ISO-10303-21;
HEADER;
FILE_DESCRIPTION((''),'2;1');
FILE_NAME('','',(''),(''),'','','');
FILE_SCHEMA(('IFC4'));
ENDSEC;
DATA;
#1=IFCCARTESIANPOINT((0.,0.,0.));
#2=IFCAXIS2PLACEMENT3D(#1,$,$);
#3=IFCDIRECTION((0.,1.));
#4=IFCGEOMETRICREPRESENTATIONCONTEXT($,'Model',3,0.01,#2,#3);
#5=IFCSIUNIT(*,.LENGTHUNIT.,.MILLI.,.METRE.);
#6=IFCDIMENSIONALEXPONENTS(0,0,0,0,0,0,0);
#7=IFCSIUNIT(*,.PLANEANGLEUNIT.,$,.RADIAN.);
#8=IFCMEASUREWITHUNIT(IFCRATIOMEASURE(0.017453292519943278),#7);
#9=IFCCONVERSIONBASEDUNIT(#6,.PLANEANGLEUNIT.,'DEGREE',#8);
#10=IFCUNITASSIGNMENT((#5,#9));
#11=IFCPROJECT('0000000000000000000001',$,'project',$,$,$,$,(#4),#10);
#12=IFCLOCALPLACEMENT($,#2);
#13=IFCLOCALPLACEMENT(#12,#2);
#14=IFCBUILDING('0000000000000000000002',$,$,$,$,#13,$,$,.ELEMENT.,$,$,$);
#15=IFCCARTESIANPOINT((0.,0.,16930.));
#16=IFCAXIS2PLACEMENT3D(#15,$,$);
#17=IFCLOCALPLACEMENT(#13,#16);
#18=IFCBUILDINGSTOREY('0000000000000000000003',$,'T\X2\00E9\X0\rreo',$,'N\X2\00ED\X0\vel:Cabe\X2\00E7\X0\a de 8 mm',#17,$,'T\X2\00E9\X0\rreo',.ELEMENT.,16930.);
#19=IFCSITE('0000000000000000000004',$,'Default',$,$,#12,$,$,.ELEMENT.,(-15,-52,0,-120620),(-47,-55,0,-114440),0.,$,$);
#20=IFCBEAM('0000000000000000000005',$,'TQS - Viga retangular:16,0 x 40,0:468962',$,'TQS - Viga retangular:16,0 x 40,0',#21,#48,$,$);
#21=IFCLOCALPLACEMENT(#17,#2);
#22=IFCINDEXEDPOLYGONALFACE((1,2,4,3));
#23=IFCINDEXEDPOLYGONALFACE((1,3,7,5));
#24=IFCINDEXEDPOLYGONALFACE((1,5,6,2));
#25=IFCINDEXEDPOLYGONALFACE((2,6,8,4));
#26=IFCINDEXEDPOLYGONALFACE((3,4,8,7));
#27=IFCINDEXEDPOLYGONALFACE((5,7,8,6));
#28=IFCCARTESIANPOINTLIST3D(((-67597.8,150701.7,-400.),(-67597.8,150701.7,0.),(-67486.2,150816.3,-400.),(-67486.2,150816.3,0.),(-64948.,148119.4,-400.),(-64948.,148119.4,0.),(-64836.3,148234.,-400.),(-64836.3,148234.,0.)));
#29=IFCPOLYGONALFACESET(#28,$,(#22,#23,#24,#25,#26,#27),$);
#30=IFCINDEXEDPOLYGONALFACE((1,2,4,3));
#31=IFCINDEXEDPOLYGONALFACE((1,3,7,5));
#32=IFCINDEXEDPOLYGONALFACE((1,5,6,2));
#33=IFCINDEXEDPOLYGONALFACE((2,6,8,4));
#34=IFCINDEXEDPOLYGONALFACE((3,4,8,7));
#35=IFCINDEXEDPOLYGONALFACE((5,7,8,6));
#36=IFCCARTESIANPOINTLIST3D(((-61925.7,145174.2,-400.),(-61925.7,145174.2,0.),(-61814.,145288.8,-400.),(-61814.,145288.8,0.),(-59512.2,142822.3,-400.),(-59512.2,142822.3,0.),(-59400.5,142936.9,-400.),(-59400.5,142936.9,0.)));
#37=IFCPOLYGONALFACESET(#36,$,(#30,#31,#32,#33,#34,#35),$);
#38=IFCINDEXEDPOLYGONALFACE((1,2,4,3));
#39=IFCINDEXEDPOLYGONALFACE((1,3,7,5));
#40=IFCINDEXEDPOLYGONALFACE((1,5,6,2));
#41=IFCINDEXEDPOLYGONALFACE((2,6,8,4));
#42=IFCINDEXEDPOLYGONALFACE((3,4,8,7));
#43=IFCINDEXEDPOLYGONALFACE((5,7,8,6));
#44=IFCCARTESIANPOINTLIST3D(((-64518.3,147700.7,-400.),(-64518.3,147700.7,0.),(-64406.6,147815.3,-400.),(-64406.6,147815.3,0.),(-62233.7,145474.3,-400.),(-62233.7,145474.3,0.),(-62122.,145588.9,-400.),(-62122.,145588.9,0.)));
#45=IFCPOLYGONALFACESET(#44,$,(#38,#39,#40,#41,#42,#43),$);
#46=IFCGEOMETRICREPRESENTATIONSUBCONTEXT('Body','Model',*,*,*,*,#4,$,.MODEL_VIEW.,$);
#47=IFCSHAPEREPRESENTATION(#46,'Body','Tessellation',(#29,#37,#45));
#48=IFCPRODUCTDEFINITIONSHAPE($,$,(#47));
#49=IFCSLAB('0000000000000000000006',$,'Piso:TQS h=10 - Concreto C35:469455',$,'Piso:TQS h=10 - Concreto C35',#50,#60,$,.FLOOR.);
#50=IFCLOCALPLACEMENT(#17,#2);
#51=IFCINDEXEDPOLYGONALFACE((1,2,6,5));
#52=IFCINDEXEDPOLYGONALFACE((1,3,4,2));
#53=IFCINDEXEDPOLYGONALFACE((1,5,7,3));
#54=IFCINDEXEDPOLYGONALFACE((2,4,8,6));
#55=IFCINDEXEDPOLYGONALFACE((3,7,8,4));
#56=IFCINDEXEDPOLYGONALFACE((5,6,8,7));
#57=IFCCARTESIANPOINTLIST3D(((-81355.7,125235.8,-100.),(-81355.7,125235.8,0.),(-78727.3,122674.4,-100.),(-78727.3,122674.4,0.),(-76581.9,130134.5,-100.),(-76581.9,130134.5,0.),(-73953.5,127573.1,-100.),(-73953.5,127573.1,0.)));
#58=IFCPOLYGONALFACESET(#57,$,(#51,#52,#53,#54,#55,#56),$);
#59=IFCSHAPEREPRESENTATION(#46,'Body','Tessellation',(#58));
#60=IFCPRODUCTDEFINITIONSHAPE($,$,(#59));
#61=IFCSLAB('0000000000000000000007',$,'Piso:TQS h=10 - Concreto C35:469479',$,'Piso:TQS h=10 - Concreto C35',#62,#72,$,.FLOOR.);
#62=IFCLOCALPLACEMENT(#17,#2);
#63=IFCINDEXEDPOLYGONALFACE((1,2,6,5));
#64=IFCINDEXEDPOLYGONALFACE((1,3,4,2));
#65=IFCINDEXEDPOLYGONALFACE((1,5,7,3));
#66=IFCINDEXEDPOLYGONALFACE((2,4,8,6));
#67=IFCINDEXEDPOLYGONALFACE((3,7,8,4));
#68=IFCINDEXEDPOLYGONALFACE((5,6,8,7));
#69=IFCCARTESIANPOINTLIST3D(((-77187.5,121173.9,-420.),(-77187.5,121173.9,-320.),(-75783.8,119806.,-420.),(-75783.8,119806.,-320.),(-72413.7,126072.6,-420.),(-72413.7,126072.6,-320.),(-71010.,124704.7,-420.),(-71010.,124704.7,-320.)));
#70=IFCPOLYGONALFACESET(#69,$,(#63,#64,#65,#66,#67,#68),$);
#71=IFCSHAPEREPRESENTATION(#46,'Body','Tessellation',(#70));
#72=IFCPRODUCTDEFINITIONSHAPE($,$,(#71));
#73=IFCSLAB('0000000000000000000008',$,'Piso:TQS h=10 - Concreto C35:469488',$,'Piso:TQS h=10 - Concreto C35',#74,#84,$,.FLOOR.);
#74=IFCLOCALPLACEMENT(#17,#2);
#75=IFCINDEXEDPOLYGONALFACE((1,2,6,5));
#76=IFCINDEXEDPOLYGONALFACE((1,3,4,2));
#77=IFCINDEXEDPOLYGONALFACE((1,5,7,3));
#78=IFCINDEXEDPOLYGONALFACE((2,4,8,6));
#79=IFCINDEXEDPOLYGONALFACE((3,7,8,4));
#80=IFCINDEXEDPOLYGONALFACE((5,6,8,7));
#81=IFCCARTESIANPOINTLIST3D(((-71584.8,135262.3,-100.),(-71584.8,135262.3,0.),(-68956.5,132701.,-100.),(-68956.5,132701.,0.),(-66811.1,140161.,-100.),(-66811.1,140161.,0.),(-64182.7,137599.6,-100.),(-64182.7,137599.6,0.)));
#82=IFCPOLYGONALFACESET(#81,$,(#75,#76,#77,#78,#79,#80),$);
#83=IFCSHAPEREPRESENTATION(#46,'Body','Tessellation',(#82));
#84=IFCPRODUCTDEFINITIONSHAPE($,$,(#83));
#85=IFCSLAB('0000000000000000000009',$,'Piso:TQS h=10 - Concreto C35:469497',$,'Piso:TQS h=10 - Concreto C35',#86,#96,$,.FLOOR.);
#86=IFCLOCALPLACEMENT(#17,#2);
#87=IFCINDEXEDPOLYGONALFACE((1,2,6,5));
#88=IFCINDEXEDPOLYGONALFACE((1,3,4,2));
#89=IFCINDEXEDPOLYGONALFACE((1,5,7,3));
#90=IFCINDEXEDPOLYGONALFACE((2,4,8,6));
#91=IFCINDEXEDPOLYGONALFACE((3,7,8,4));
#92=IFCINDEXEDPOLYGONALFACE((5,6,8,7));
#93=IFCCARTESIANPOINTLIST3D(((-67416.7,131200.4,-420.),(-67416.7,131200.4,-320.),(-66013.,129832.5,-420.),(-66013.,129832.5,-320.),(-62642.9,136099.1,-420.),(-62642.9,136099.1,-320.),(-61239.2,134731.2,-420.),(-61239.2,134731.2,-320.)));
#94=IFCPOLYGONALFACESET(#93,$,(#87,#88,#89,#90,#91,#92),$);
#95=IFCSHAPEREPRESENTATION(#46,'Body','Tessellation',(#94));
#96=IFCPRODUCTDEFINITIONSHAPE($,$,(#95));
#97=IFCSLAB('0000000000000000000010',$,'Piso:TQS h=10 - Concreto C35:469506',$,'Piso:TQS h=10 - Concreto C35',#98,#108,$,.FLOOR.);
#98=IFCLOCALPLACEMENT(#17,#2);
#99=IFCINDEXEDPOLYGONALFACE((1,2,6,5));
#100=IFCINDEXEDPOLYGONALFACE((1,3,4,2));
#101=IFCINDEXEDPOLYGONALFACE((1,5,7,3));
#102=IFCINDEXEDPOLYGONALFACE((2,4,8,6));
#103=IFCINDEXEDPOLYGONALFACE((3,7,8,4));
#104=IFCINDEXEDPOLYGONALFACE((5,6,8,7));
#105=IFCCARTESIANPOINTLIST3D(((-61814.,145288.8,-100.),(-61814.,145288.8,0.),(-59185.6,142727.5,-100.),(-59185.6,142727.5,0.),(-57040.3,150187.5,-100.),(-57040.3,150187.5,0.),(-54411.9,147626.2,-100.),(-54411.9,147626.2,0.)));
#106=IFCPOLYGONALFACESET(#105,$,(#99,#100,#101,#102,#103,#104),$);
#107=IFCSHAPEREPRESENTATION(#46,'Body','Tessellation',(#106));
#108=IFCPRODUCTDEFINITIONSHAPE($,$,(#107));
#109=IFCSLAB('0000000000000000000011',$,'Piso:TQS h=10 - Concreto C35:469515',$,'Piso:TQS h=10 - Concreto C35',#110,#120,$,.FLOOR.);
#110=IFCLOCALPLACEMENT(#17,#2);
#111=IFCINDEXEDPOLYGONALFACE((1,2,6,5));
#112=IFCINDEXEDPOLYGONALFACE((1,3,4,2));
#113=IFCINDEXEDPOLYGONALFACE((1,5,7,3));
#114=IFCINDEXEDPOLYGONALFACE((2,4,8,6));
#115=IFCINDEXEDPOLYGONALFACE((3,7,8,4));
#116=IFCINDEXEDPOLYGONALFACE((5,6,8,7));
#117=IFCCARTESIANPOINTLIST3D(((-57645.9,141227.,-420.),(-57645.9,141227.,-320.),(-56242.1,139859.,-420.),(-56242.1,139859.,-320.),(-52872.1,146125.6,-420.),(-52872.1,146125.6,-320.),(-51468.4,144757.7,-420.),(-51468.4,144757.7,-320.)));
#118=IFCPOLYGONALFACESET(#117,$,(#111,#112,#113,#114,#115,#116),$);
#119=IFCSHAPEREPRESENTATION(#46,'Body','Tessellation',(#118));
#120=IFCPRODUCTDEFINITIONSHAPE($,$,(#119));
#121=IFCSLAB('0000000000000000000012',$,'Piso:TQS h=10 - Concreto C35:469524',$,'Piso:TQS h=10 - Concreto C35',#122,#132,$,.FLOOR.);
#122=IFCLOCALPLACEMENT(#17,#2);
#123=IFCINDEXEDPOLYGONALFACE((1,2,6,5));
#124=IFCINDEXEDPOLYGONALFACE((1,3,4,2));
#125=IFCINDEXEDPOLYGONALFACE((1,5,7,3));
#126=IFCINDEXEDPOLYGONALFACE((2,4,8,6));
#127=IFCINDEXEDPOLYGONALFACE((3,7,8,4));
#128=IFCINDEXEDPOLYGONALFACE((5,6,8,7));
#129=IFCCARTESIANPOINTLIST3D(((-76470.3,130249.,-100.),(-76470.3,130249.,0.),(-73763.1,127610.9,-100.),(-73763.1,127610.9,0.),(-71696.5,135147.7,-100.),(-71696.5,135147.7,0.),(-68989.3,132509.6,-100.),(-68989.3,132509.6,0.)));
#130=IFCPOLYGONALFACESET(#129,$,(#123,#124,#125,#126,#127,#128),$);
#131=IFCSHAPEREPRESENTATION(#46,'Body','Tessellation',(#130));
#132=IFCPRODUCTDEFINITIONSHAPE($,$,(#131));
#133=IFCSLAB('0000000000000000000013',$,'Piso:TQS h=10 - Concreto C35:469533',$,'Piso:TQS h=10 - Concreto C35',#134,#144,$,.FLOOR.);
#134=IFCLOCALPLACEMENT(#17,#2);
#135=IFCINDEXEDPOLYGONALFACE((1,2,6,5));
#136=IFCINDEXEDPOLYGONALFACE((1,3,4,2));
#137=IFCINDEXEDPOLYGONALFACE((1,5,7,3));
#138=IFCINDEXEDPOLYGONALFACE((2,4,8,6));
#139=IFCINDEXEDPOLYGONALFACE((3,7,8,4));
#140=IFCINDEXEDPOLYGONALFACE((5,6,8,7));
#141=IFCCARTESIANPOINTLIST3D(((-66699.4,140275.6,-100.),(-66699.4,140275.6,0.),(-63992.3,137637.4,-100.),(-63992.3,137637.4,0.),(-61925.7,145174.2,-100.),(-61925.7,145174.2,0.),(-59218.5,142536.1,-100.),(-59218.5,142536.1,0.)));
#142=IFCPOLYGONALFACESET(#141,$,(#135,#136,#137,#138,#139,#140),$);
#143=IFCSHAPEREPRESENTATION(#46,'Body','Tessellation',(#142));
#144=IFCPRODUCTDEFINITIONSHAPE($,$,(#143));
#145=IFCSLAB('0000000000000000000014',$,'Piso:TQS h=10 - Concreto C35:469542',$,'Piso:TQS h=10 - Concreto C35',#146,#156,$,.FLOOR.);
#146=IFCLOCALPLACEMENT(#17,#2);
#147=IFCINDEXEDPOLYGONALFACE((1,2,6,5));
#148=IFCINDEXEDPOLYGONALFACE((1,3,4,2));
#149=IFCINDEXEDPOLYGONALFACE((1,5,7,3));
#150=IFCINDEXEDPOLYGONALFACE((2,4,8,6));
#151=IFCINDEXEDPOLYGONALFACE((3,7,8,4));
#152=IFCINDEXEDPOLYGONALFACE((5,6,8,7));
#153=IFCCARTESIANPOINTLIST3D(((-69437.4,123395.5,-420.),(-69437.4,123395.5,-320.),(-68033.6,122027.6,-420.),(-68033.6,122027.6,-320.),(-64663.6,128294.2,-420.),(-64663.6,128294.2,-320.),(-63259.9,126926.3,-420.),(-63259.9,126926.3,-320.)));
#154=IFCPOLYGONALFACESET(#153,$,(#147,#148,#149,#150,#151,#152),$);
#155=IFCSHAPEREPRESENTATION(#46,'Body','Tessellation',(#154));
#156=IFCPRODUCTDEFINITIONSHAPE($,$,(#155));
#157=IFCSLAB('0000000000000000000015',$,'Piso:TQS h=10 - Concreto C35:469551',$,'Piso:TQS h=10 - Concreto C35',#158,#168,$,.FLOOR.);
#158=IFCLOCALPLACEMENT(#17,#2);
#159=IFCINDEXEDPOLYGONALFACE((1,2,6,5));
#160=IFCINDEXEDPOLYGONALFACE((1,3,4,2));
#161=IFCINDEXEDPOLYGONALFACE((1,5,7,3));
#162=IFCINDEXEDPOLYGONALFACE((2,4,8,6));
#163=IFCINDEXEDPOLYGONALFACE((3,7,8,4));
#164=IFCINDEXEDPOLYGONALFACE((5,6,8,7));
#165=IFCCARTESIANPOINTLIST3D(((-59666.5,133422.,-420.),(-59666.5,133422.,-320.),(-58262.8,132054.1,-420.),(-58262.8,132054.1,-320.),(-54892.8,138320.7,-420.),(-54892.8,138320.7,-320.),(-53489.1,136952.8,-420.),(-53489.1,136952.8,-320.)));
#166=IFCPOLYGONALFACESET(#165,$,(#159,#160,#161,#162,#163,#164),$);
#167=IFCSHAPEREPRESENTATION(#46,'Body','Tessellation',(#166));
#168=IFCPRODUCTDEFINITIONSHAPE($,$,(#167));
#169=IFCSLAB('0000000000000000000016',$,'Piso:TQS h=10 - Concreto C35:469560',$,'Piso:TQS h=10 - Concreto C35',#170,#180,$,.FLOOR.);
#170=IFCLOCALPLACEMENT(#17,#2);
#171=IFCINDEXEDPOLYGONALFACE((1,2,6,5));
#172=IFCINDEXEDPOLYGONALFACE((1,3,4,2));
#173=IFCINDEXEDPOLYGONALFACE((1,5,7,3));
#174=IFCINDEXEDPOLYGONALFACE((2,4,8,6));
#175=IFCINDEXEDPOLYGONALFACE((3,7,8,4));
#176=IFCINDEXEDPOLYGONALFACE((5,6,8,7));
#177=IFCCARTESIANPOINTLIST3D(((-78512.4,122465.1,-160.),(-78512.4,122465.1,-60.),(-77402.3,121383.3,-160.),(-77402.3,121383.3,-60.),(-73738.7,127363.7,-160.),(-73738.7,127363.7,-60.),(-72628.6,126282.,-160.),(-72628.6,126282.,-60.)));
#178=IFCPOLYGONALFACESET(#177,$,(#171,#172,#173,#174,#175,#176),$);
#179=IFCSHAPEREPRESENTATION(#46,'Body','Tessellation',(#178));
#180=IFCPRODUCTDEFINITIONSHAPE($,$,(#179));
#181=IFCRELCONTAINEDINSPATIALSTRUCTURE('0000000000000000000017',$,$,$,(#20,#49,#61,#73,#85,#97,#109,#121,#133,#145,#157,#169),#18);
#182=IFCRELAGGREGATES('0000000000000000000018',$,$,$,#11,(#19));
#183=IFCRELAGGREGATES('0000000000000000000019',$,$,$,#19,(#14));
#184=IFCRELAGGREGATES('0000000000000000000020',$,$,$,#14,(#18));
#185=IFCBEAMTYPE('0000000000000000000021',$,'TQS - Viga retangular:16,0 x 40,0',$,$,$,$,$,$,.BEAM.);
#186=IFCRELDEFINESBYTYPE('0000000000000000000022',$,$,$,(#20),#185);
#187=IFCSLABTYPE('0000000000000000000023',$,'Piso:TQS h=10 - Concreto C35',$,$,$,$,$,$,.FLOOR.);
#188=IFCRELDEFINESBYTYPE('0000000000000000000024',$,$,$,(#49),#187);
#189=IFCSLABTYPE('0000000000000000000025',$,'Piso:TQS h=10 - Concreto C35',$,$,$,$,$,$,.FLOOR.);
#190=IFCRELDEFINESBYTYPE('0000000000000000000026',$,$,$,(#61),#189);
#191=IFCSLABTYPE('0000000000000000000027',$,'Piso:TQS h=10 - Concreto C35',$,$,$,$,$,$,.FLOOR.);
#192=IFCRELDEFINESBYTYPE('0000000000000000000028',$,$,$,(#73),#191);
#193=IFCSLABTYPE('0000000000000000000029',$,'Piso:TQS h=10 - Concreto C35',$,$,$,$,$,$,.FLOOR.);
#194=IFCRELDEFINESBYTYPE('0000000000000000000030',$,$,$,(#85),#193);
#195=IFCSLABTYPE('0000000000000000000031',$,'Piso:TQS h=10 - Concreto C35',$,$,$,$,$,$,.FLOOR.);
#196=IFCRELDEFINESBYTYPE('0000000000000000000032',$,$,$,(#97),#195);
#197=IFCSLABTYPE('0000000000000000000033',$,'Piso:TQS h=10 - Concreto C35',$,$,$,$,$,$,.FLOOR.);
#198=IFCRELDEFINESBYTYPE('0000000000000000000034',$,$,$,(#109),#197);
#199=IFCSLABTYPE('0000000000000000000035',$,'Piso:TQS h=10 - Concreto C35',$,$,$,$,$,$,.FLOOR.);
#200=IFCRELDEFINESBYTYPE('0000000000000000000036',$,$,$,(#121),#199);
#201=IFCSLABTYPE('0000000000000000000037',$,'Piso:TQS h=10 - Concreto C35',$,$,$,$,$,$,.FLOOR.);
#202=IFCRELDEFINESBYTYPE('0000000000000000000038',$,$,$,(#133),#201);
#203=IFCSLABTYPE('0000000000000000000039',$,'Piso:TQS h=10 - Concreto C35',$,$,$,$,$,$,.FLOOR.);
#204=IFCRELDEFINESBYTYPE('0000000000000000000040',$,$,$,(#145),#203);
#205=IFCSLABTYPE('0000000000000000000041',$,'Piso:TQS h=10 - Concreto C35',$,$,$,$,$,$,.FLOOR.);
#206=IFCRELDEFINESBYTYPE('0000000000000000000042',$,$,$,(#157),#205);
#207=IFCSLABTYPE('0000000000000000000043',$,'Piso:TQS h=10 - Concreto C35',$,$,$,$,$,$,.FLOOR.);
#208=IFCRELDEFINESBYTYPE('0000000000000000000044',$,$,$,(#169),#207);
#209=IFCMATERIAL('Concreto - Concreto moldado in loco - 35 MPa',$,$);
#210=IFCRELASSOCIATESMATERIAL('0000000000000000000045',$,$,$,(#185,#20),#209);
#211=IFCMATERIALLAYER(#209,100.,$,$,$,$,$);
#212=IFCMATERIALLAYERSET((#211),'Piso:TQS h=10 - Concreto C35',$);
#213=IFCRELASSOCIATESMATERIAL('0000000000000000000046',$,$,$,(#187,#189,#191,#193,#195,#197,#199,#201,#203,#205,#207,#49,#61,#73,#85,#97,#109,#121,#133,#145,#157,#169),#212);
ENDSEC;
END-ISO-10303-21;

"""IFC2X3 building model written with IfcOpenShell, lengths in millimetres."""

from ifc_helpers import new_model, entity, si_unit, converted_unit, direction, frame, frame_2d, origin, place, context, subcontext, project, spatial, rectangle, extrude, source, transform, mapped, material, layer, layer_set, layer_usage, type_object, type_shapes, element, save


model = new_model("IFC2X3")

# Units and contexts
model_context = context("Model", 3, precision=0.01, world=origin(), true_north=direction((0.0, 1.0)))
body_context = subcontext(model_context, "Body", "Model", "MODEL_VIEW")
ifc_project = project(units=[si_unit("LENGTHUNIT", "METRE", prefix="MILLI"), converted_unit("PLANEANGLEUNIT", "DEGREE", entity("IfcRatioMeasure", 0.017453292519943278), si_unit("PLANEANGLEUNIT", "RADIAN"), dimensions=[0, 0, 0, 0, 0, 0, 0])], contexts=[model_context])

# Site, building, storey
site_placement = place(None, origin())
site = spatial("IfcSite", under=ifc_project, at=site_placement, Name="Default", CompositionType="ELEMENT", RefLatitude=(-15, -52, 0, -120620), RefLongitude=(-47, -55, 0, -114440), RefElevation=0.0)
building_placement = place(site_placement, origin())
building = spatial("IfcBuilding", under=site, at=building_placement, CompositionType="ELEMENT")
storey_placement = place(building_placement, frame((0.0, 0.0, 16930.0)))
storey = spatial("IfcBuildingStorey", under=building, at=storey_placement, Name="Térreo", ObjectType="Nível:Cabeça de 8 mm", LongName="Térreo", CompositionType="ELEMENT", Elevation=16930.0)

# Beam
ifc_material = material(Name="Concreto - Concreto moldado in loco - 35 MPa")
beam_type_1 = type_object("IfcBeamType", Name="TQS - Viga retangular:16,0 x 40,0", PredefinedType="BEAM", material=ifc_material)
shared_shape_1 = source(origin(), body_context, "Body", "SweptSolid", [
    extrude(rectangle(XDim=400.0, YDim=160.0, at=frame_2d((0.0, 0.0), x_axis=(1.0, 0.0))), frame((-64892.1, 148176.7, 16730.0), z_axis=(-0.71618, 0.697915, 0.0), x_axis=(0.0, 0.0, 1.0)), (0.0, 0.0, 1.0), 3700.0),
    extrude(rectangle(XDim=400.0, YDim=160.0, at=frame_2d((0.0, 0.0), x_axis=(1.0, 0.0))), frame((-59456.3, 142879.6, 16730.0), z_axis=(-0.71618, 0.697915, 0.0), x_axis=(0.0, 0.0, 1.0)), (0.0, 0.0, 1.0), 3370.0),
    extrude(rectangle(XDim=400.0, YDim=160.0, at=frame_2d((0.0, 0.0), x_axis=(1.0, 0.0))), frame((-62177.8, 145531.6, 16730.0), z_axis=(-0.71618, 0.697915, 0.0), x_axis=(0.0, 0.0, 1.0)), (0.0, 0.0, 1.0), 3190.0),
])
type_shapes(beam_type_1, [shared_shape_1])
beam_1_placement = place(storey_placement, frame((0.0, 0.0, -16930.0)))
element("IfcBeam", 1, at=beam_1_placement, inside=storey, type_object=beam_type_1, material=ifc_material, Name="TQS - Viga retangular:16,0 x 40,0:468962", ObjectType="TQS - Viga retangular:16,0 x 40,0", context=body_context, shape_type="MappedRepresentation", body=[
    mapped(shared_shape_1, transform((0.0, 0.0, 0.0), scale=1.0)),
])

# Slabs
ifc_layer = layer(ifc_material, 100.0)
ifc_layer_set = layer_set([ifc_layer], Name="Piso:TQS h=10 - Concreto C35")
ifc_layer_usage_1 = layer_usage(ifc_layer_set, "AXIS3", "POSITIVE", 0.0)
slab_type_1 = type_object("IfcSlabType", Name="Piso:TQS h=10 - Concreto C35", PredefinedType="FLOOR", material=ifc_layer_set)
slab_1_placement = place(storey_placement, origin())
element("IfcSlab", 2, at=slab_1_placement, inside=storey, type_object=slab_type_1, material=ifc_layer_usage_1, Name="Piso:TQS h=10 - Concreto C35:469455", ObjectType="Piso:TQS h=10 - Concreto C35", PredefinedType="FLOOR", context=body_context, shape_type="SweptSolid", body=[
    extrude(rectangle(XDim=3670.0, YDim=6840.0, at=frame_2d((0.0, 0.0), x_axis=(1.0, 0.0))), frame((-77654.6, 126404.4, 0.0), z_axis=(0.0, 0.0, -1.0), x_axis=(0.71618, -0.697915, 0.0)), (0.0, 0.0, 1.0), 100.0),
])
ifc_layer_usage_2 = layer_usage(ifc_layer_set, "AXIS3", "POSITIVE", 0.0)
slab_type_2 = type_object("IfcSlabType", Name="Piso:TQS h=10 - Concreto C35", PredefinedType="FLOOR", material=ifc_layer_set)
slab_2_placement = place(storey_placement, origin())
element("IfcSlab", 3, at=slab_2_placement, inside=storey, type_object=slab_type_2, material=ifc_layer_usage_2, Name="Piso:TQS h=10 - Concreto C35:469479", ObjectType="Piso:TQS h=10 - Concreto C35", PredefinedType="FLOOR", context=body_context, shape_type="SweptSolid", body=[
    extrude(rectangle(XDim=1960.0, YDim=6840.0, at=frame_2d((0.0, 0.0), x_axis=(1.0, 0.0))), frame((-74098.8, 122939.3, -320.0), z_axis=(0.0, 0.0, -1.0), x_axis=(0.71618, -0.697915, 0.0)), (0.0, 0.0, 1.0), 100.0),
])
ifc_layer_usage_3 = layer_usage(ifc_layer_set, "AXIS3", "POSITIVE", 0.0)
slab_type_3 = type_object("IfcSlabType", Name="Piso:TQS h=10 - Concreto C35", PredefinedType="FLOOR", material=ifc_layer_set)
slab_3_placement = place(storey_placement, origin())
element("IfcSlab", 4, at=slab_3_placement, inside=storey, type_object=slab_type_3, material=ifc_layer_usage_3, Name="Piso:TQS h=10 - Concreto C35:469488", ObjectType="Piso:TQS h=10 - Concreto C35", PredefinedType="FLOOR", context=body_context, shape_type="SweptSolid", body=[
    extrude(rectangle(XDim=3670.0, YDim=6840.0, at=frame_2d((0.0, 0.0), x_axis=(1.0, 0.0))), frame((-67883.8, 136431.0, 0.0), z_axis=(0.0, 0.0, -1.0), x_axis=(0.71618, -0.697915, 0.0)), (0.0, 0.0, 1.0), 100.0),
])
ifc_layer_usage_4 = layer_usage(ifc_layer_set, "AXIS3", "POSITIVE", 0.0)
slab_type_4 = type_object("IfcSlabType", Name="Piso:TQS h=10 - Concreto C35", PredefinedType="FLOOR", material=ifc_layer_set)
slab_4_placement = place(storey_placement, origin())
element("IfcSlab", 5, at=slab_4_placement, inside=storey, type_object=slab_type_4, material=ifc_layer_usage_4, Name="Piso:TQS h=10 - Concreto C35:469497", ObjectType="Piso:TQS h=10 - Concreto C35", PredefinedType="FLOOR", context=body_context, shape_type="SweptSolid", body=[
    extrude(rectangle(XDim=6840.0, YDim=1960.0, at=frame_2d((0.0, 0.0), x_axis=(1.0, 0.0))), frame((-64327.9, 132965.8, -320.0), z_axis=(0.0, 0.0, -1.0), x_axis=(-0.697915, -0.71618, 0.0)), (0.0, 0.0, 1.0), 100.0),
])
ifc_layer_usage_5 = layer_usage(ifc_layer_set, "AXIS3", "POSITIVE", 0.0)
slab_type_5 = type_object("IfcSlabType", Name="Piso:TQS h=10 - Concreto C35", PredefinedType="FLOOR", material=ifc_layer_set)
slab_5_placement = place(storey_placement, origin())
element("IfcSlab", 6, at=slab_5_placement, inside=storey, type_object=slab_type_5, material=ifc_layer_usage_5, Name="Piso:TQS h=10 - Concreto C35:469506", ObjectType="Piso:TQS h=10 - Concreto C35", PredefinedType="FLOOR", context=body_context, shape_type="SweptSolid", body=[
    extrude(rectangle(XDim=3670.0, YDim=6840.0, at=frame_2d((0.0, 0.0), x_axis=(1.0, 0.0))), frame((-58113.0, 146457.5, 0.0), z_axis=(0.0, 0.0, -1.0), x_axis=(0.71618, -0.697915, 0.0)), (0.0, 0.0, 1.0), 100.0),
])
ifc_layer_usage_6 = layer_usage(ifc_layer_set, "AXIS3", "POSITIVE", 0.0)
slab_type_6 = type_object("IfcSlabType", Name="Piso:TQS h=10 - Concreto C35", PredefinedType="FLOOR", material=ifc_layer_set)
slab_6_placement = place(storey_placement, origin())
element("IfcSlab", 7, at=slab_6_placement, inside=storey, type_object=slab_type_6, material=ifc_layer_usage_6, Name="Piso:TQS h=10 - Concreto C35:469515", ObjectType="Piso:TQS h=10 - Concreto C35", PredefinedType="FLOOR", context=body_context, shape_type="SweptSolid", body=[
    extrude(rectangle(XDim=6840.0, YDim=1960.0, at=frame_2d((0.0, 0.0), x_axis=(1.0, 0.0))), frame((-54557.1, 142992.3, -320.0), z_axis=(0.0, 0.0, -1.0), x_axis=(-0.697915, -0.71618, 0.0)), (0.0, 0.0, 1.0), 100.0),
])
ifc_layer_usage_7 = layer_usage(ifc_layer_set, "AXIS3", "POSITIVE", 0.0)
slab_type_7 = type_object("IfcSlabType", Name="Piso:TQS h=10 - Concreto C35", PredefinedType="FLOOR", material=ifc_layer_set)
slab_7_placement = place(storey_placement, origin())
element("IfcSlab", 8, at=slab_7_placement, inside=storey, type_object=slab_type_7, material=ifc_layer_usage_7, Name="Piso:TQS h=10 - Concreto C35:469524", ObjectType="Piso:TQS h=10 - Concreto C35", PredefinedType="FLOOR", context=body_context, shape_type="SweptSolid", body=[
    extrude(rectangle(XDim=3780.0, YDim=6840.0, at=frame_2d((0.0, 0.0), x_axis=(1.0, 0.0))), frame((-72729.8, 131379.3, 0.0), z_axis=(0.0, 0.0, -1.0), x_axis=(0.71618, -0.697915, 0.0)), (0.0, 0.0, 1.0), 100.0),
])
ifc_layer_usage_8 = layer_usage(ifc_layer_set, "AXIS3", "POSITIVE", 0.0)
slab_type_8 = type_object("IfcSlabType", Name="Piso:TQS h=10 - Concreto C35", PredefinedType="FLOOR", material=ifc_layer_set)
slab_8_placement = place(storey_placement, origin())
element("IfcSlab", 9, at=slab_8_placement, inside=storey, type_object=slab_type_8, material=ifc_layer_usage_8, Name="Piso:TQS h=10 - Concreto C35:469533", ObjectType="Piso:TQS h=10 - Concreto C35", PredefinedType="FLOOR", context=body_context, shape_type="SweptSolid", body=[
    extrude(rectangle(XDim=3780.0, YDim=6840.0, at=frame_2d((0.0, 0.0), x_axis=(1.0, 0.0))), frame((-62959.0, 141405.8, 0.0), z_axis=(0.0, 0.0, -1.0), x_axis=(0.71618, -0.697915, 0.0)), (0.0, 0.0, 1.0), 100.0),
])
ifc_layer_usage_9 = layer_usage(ifc_layer_set, "AXIS3", "POSITIVE", 0.0)
slab_type_9 = type_object("IfcSlabType", Name="Piso:TQS h=10 - Concreto C35", PredefinedType="FLOOR", material=ifc_layer_set)
slab_9_placement = place(storey_placement, origin())
element("IfcSlab", 10, at=slab_9_placement, inside=storey, type_object=slab_type_9, material=ifc_layer_usage_9, Name="Piso:TQS h=10 - Concreto C35:469542", ObjectType="Piso:TQS h=10 - Concreto C35", PredefinedType="FLOOR", context=body_context, shape_type="SweptSolid", body=[
    extrude(rectangle(XDim=6840.0, YDim=1960.0, at=frame_2d((0.0, 0.0), x_axis=(1.0, 0.0))), frame((-66348.6, 125160.9, -320.0), z_axis=(0.0, 0.0, -1.0), x_axis=(-0.697915, -0.71618, 0.0)), (0.0, 0.0, 1.0), 100.0),
])
ifc_layer_usage_10 = layer_usage(ifc_layer_set, "AXIS3", "POSITIVE", 0.0)
slab_type_10 = type_object("IfcSlabType", Name="Piso:TQS h=10 - Concreto C35", PredefinedType="FLOOR", material=ifc_layer_set)
slab_10_placement = place(storey_placement, origin())
element("IfcSlab", 11, at=slab_10_placement, inside=storey, type_object=slab_type_10, material=ifc_layer_usage_10, Name="Piso:TQS h=10 - Concreto C35:469551", ObjectType="Piso:TQS h=10 - Concreto C35", PredefinedType="FLOOR", context=body_context, shape_type="SweptSolid", body=[
    extrude(rectangle(XDim=1960.0, YDim=6840.0, at=frame_2d((0.0, 0.0), x_axis=(1.0, 0.0))), frame((-56577.8, 135187.4, -320.0), z_axis=(0.0, 0.0, -1.0), x_axis=(0.71618, -0.697915, 0.0)), (0.0, 0.0, 1.0), 100.0),
])
ifc_layer_usage_11 = layer_usage(ifc_layer_set, "AXIS3", "POSITIVE", 0.0)
slab_type_11 = type_object("IfcSlabType", Name="Piso:TQS h=10 - Concreto C35", PredefinedType="FLOOR", material=ifc_layer_set)
slab_11_placement = place(storey_placement, origin())
element("IfcSlab", 12, at=slab_11_placement, inside=storey, type_object=slab_type_11, material=ifc_layer_usage_11, Name="Piso:TQS h=10 - Concreto C35:469560", ObjectType="Piso:TQS h=10 - Concreto C35", PredefinedType="FLOOR", context=body_context, shape_type="SweptSolid", body=[
    extrude(rectangle(XDim=6840.0, YDim=1550.0, at=frame_2d((0.0, 0.0), x_axis=(1.0, 0.0))), frame((-75570.5, 124373.5, -60.0), z_axis=(0.0, 0.0, -1.0), x_axis=(-0.697915, -0.71618, 0.0)), (0.0, 0.0, 1.0), 100.0),
])

save(model, "model.ifc")
